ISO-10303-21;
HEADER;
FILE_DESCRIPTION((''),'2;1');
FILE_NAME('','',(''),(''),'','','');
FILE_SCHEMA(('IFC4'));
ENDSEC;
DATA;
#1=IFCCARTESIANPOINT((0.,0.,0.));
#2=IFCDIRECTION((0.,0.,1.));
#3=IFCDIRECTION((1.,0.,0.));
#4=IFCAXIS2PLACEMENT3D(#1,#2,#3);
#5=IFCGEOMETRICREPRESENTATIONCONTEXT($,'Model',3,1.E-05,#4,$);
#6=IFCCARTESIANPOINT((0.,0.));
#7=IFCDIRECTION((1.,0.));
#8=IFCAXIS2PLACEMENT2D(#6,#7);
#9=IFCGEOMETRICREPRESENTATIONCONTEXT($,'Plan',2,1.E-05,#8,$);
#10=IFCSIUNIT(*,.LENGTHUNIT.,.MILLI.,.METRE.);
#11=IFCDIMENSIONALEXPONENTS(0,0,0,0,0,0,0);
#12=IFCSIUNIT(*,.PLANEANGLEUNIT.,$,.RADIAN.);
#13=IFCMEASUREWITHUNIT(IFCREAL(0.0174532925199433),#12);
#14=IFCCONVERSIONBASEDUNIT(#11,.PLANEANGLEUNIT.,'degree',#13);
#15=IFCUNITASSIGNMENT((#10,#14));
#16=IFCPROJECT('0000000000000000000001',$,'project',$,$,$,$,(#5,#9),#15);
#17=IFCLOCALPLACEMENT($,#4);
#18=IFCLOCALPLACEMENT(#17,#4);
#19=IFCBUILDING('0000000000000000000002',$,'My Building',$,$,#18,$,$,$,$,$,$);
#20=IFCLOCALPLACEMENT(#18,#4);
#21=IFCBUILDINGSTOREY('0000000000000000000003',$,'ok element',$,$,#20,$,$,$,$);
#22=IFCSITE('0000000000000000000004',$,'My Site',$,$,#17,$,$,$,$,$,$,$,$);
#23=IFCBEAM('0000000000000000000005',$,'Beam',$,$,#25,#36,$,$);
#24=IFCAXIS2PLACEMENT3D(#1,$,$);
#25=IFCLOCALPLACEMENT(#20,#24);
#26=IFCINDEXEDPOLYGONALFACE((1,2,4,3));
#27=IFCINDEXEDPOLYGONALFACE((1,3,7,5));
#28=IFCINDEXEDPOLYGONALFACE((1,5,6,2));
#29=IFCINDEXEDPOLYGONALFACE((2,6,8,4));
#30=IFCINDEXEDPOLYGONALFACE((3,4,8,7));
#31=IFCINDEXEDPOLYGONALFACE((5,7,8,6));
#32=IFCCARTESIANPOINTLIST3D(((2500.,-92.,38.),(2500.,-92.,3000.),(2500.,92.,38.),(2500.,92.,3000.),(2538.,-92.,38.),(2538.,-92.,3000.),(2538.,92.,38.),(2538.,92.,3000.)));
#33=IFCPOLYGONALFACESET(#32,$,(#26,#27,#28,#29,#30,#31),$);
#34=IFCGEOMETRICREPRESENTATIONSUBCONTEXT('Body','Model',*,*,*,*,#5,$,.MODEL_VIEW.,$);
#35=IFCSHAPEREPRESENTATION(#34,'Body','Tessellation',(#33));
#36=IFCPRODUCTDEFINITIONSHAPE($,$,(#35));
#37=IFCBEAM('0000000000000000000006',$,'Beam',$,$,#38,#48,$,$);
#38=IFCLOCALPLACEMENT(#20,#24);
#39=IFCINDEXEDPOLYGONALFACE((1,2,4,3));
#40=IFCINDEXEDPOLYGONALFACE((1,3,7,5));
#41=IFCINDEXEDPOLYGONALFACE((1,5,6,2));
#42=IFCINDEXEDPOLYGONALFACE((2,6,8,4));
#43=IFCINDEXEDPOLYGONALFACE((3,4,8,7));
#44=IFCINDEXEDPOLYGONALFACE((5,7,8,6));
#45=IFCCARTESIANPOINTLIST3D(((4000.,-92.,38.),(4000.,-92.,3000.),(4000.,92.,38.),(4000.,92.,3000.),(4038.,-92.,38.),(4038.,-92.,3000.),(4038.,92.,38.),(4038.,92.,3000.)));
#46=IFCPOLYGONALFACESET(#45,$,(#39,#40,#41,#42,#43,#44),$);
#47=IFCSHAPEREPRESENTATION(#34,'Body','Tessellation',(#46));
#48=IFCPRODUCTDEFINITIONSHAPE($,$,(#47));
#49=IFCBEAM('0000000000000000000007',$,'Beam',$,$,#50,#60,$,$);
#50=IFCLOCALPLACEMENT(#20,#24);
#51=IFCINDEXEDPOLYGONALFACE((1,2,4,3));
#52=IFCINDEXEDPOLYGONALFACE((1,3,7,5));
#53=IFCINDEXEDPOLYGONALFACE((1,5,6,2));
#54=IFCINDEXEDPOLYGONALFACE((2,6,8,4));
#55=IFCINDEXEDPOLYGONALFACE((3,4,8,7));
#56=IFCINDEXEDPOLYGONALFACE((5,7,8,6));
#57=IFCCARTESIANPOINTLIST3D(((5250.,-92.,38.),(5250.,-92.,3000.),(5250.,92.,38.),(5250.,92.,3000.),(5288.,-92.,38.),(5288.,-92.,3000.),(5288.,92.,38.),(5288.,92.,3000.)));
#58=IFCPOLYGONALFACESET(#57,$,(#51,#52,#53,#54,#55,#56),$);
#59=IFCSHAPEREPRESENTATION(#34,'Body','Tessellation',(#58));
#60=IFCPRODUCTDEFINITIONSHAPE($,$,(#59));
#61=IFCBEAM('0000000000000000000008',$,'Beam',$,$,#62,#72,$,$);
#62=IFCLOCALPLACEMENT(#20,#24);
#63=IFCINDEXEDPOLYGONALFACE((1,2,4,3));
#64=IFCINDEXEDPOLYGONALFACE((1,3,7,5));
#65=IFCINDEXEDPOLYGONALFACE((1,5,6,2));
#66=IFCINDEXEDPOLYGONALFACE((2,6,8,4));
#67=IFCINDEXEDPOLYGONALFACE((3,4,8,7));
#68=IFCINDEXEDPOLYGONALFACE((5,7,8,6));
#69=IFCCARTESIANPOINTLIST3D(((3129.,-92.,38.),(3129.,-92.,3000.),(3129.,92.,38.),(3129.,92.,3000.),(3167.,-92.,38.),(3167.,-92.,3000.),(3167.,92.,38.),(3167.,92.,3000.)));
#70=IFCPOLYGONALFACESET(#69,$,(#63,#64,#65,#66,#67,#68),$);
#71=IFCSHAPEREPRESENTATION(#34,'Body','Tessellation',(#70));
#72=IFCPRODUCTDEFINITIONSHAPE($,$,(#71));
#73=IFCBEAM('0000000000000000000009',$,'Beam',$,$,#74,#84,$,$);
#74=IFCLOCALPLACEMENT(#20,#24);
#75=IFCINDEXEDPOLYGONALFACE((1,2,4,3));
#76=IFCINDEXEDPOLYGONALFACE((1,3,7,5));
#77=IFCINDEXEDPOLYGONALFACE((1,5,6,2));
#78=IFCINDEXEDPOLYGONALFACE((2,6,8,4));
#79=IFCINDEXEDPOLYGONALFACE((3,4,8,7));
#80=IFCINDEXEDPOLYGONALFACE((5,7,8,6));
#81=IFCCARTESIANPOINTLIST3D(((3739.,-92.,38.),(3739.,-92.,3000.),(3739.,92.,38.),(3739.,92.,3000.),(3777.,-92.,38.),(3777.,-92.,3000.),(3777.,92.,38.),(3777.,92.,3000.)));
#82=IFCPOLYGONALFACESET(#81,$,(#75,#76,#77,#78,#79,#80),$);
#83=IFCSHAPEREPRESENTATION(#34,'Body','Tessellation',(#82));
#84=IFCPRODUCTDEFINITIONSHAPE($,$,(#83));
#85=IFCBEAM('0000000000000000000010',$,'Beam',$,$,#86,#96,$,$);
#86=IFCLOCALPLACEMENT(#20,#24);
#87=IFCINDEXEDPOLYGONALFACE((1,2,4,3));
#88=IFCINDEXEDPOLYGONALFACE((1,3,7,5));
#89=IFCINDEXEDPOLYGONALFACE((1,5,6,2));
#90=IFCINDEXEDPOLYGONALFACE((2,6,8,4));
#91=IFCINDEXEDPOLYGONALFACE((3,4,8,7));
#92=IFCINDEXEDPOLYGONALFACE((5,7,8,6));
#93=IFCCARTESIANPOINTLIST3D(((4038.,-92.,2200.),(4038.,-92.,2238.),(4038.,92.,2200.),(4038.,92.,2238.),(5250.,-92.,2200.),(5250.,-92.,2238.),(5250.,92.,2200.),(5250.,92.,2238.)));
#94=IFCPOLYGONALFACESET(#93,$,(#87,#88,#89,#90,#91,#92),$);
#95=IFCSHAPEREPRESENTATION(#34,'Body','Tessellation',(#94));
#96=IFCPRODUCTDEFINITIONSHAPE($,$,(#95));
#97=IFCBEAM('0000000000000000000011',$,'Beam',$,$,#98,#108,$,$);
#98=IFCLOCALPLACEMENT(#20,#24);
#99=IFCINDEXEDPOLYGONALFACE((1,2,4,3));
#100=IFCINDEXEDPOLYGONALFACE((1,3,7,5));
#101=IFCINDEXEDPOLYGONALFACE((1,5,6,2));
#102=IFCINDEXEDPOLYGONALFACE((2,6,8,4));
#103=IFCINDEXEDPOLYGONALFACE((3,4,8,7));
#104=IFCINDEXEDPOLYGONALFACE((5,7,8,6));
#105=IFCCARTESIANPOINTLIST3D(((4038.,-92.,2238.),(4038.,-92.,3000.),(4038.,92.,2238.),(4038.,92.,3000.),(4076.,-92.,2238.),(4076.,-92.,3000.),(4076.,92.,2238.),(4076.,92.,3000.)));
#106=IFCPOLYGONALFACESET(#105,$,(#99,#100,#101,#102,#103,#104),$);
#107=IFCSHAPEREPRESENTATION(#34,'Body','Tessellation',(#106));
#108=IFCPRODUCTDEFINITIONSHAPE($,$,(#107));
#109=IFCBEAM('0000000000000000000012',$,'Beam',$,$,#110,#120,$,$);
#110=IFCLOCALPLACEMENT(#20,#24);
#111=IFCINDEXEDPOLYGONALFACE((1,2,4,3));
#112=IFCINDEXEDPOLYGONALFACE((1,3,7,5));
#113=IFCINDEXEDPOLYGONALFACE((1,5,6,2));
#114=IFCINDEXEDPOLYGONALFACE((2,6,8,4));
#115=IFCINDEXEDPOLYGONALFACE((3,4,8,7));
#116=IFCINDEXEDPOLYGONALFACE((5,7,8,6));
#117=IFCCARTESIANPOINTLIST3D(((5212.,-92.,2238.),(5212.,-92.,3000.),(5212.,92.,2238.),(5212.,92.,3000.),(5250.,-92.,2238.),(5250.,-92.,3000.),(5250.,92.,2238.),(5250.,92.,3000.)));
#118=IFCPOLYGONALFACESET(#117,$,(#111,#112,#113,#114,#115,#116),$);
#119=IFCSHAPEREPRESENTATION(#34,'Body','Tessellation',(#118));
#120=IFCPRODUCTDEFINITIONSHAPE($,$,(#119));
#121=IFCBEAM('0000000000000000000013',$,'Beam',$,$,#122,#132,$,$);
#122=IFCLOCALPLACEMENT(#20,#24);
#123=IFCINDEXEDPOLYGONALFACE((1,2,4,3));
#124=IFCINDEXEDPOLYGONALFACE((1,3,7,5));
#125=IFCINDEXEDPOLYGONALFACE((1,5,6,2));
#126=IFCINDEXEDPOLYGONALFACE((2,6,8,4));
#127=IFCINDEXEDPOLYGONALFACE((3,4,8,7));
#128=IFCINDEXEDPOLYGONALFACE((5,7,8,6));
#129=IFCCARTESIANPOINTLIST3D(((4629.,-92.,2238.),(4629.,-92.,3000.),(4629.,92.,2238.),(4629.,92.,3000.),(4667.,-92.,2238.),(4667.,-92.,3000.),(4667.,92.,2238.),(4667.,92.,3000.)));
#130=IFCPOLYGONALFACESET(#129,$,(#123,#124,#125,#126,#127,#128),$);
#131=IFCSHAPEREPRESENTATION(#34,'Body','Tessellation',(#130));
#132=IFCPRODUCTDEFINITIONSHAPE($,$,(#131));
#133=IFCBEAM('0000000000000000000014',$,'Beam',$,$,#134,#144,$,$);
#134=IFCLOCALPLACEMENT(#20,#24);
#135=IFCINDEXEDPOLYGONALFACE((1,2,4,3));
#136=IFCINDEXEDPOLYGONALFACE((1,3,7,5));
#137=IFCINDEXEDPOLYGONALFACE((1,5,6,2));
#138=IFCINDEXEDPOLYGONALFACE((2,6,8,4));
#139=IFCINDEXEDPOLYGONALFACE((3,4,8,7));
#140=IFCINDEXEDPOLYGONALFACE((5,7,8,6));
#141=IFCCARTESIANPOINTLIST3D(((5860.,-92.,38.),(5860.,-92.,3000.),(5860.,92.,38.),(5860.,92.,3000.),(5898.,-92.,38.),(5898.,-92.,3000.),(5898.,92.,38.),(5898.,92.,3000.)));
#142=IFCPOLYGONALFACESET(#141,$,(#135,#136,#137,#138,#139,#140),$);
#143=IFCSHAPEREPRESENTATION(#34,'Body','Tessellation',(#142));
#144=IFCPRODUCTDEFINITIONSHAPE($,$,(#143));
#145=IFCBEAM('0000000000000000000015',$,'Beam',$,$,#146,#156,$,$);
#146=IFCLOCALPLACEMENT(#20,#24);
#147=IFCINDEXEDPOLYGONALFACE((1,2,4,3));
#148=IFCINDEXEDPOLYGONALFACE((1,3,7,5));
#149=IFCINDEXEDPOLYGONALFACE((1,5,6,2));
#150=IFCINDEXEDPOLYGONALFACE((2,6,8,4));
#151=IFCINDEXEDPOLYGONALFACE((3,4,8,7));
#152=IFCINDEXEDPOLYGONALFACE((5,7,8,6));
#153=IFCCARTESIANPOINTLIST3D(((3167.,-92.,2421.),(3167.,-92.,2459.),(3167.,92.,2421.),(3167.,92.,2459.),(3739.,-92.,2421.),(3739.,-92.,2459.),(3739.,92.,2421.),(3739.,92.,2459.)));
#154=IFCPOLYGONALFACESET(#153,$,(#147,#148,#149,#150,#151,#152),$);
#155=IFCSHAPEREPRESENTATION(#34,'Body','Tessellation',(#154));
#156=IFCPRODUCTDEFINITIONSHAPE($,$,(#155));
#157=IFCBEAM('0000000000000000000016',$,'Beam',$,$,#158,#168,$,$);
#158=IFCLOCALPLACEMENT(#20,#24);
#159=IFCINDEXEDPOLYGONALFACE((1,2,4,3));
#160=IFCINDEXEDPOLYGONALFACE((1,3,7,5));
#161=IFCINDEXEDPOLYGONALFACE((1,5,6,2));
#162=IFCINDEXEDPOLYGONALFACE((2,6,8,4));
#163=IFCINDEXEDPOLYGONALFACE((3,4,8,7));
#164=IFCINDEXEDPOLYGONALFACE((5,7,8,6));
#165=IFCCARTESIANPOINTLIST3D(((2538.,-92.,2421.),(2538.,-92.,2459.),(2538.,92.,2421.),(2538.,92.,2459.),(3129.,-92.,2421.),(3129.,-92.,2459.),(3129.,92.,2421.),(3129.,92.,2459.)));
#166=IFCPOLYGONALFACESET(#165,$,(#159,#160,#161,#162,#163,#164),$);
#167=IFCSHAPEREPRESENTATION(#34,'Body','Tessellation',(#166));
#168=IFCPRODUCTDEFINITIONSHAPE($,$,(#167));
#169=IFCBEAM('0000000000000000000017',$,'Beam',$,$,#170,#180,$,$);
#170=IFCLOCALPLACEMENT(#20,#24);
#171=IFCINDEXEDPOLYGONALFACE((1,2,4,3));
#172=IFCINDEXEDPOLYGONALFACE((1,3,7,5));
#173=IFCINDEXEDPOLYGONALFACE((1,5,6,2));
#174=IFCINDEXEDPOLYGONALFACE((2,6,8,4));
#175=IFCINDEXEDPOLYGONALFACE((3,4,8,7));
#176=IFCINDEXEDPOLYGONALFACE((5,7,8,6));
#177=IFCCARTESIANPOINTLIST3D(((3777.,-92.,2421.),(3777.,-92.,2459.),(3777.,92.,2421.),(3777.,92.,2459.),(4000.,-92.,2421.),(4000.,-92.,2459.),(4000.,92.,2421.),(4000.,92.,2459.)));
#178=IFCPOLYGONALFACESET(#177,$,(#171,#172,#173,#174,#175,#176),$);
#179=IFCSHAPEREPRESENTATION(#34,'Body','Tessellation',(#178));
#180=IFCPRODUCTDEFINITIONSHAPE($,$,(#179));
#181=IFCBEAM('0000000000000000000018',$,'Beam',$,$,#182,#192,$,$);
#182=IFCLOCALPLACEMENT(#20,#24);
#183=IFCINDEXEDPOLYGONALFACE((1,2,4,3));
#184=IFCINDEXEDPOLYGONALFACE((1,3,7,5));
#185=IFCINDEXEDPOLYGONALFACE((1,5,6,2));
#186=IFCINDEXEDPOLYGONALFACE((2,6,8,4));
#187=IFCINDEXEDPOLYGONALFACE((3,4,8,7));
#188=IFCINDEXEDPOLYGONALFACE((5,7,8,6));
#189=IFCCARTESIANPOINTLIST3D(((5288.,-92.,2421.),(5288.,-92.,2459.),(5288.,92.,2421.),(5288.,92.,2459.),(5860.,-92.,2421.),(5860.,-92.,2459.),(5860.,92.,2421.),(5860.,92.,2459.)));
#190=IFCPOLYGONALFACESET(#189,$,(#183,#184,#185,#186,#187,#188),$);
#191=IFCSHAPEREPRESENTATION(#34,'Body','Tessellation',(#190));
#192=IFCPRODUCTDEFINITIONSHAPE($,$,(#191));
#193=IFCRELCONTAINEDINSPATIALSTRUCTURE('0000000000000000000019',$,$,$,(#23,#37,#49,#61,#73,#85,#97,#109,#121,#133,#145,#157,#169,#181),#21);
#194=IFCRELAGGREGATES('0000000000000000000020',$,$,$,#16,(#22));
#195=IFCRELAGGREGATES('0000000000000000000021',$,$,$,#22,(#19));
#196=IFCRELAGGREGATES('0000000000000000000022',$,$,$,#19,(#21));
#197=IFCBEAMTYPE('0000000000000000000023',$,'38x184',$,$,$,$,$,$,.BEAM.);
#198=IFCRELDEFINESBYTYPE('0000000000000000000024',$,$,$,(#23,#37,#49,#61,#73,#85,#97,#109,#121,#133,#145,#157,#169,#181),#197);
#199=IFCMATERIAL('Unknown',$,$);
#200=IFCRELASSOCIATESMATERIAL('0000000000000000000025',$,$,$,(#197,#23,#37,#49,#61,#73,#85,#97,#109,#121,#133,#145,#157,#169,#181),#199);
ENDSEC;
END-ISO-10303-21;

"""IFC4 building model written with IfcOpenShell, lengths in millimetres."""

from ifc_helpers import new_model, entity, si_unit, converted_unit, frame, origin_with_axes, origin_2d_with_axis, place, context, subcontext, project, spatial, rectangle, extrude, material, material_profile, profile_set, profile_usage, type_object, element, save


model = new_model("IFC4")

# Units and contexts
model_context = context("Model", 3, precision=1e-05, world=origin_with_axes())
plan_context = context("Plan", 2, precision=1e-05, world=origin_2d_with_axis())
body_context = subcontext(model_context, "Body", "Model", "MODEL_VIEW")
ifc_project = project(units=[si_unit("LENGTHUNIT", "METRE", prefix="MILLI"), converted_unit("PLANEANGLEUNIT", "degree", entity("IfcReal", 0.0174532925199433), si_unit("PLANEANGLEUNIT", "RADIAN"), dimensions=[0, 0, 0, 0, 0, 0, 0])], contexts=[model_context, plan_context])

# Site, building, storey
site_placement = place(None, origin_with_axes())
site = spatial("IfcSite", under=ifc_project, at=site_placement, Name="My Site")
building_placement = place(site_placement, origin_with_axes())
building = spatial("IfcBuilding", under=site, at=building_placement, Name="My Building")
storey_placement = place(building_placement, origin_with_axes())
storey = spatial("IfcBuildingStorey", under=building, at=storey_placement, Name="ok element")

# Beams
ifc_material = material(Name="Unknown")
ifc_material_profile = material_profile(ifc_material, rectangle(XDim=184.0, YDim=38.0))
ifc_profile_set = profile_set([ifc_material_profile], Name="vurenhout")
beam_type = type_object("IfcBeamType", Name="38x184", PredefinedType="BEAM", material=ifc_profile_set)
ifc_profile_usage_1 = profile_usage(ifc_profile_set, cardinal=2)
beam_1_placement = place(storey_placement, frame((2538.0, 0.0, 38.0), z_axis=(0.0, 0.0, 1.0), x_axis=(0.0, 1.0, 0.0)))
element("IfcBeam", 1, at=beam_1_placement, inside=storey, type_object=beam_type, material=ifc_profile_usage_1, Name="Beam", context=body_context, shape_type="SweptSolid", body=[
    extrude(rectangle(XDim=184.0, YDim=38.0), frame((0.0, 19.0, 0.0), z_axis=(0.0, 0.0, 1.0), x_axis=(1.0, 0.0, 0.0)), (0.0, 0.0, 1.0), 2962.0),
])
ifc_profile_usage_2 = profile_usage(ifc_profile_set, cardinal=2)
beam_2_placement = place(storey_placement, frame((4038.0, 0.0, 38.0), z_axis=(0.0, 0.0, 1.0), x_axis=(0.0, 1.0, 0.0)))
element("IfcBeam", 2, at=beam_2_placement, inside=storey, type_object=beam_type, material=ifc_profile_usage_2, Name="Beam", context=body_context, shape_type="SweptSolid", body=[
    extrude(rectangle(XDim=184.0, YDim=38.0), frame((0.0, 19.0, 0.0), z_axis=(0.0, 0.0, 1.0), x_axis=(1.0, 0.0, 0.0)), (0.0, 0.0, 1.0), 2962.0),
])
ifc_profile_usage_3 = profile_usage(ifc_profile_set, cardinal=2)
beam_3_placement = place(storey_placement, frame((5288.0, 0.0, 38.0), z_axis=(0.0, 0.0, 1.0), x_axis=(0.0, 1.0, 0.0)))
element("IfcBeam", 3, at=beam_3_placement, inside=storey, type_object=beam_type, material=ifc_profile_usage_3, Name="Beam", context=body_context, shape_type="SweptSolid", body=[
    extrude(rectangle(XDim=184.0, YDim=38.0), frame((0.0, 19.0, 0.0), z_axis=(0.0, 0.0, 1.0), x_axis=(1.0, 0.0, 0.0)), (0.0, 0.0, 1.0), 2962.0),
])
ifc_profile_usage_4 = profile_usage(ifc_profile_set, cardinal=5)
beam_4_placement = place(storey_placement, frame((3148.0, 0.0, 38.0), z_axis=(0.0, 0.0, 1.0), x_axis=(0.0, 1.0, 0.0)))
element("IfcBeam", 4, at=beam_4_placement, inside=storey, type_object=beam_type, material=ifc_profile_usage_4, Name="Beam", context=body_context, shape_type="SweptSolid", body=[
    extrude(rectangle(XDim=184.0, YDim=38.0), origin_with_axes(), (0.0, 0.0, 1.0), 2962.0),
])
ifc_profile_usage_5 = profile_usage(ifc_profile_set, cardinal=5)
beam_5_placement = place(storey_placement, frame((3758.0, 0.0, 38.0), z_axis=(0.0, 0.0, 1.0), x_axis=(0.0, 1.0, 0.0)))
element("IfcBeam", 5, at=beam_5_placement, inside=storey, type_object=beam_type, material=ifc_profile_usage_5, Name="Beam", context=body_context, shape_type="SweptSolid", body=[
    extrude(rectangle(XDim=184.0, YDim=38.0), origin_with_axes(), (0.0, 0.0, 1.0), 2962.0),
])
ifc_profile_usage_6 = profile_usage(ifc_profile_set, cardinal=2)
beam_6_placement = place(storey_placement, frame((4038.0, 0.0, 2200.0), z_axis=(1.0, 0.0, 0.0), x_axis=(0.0, 1.0, 0.0)))
element("IfcBeam", 6, at=beam_6_placement, inside=storey, type_object=beam_type, material=ifc_profile_usage_6, Name="Beam", context=body_context, shape_type="SweptSolid", body=[
    extrude(rectangle(XDim=184.0, YDim=38.0), frame((0.0, 19.0, 0.0), z_axis=(0.0, 0.0, 1.0), x_axis=(1.0, 0.0, 0.0)), (0.0, 0.0, 1.0), 1212.0),
])
ifc_profile_usage_7 = profile_usage(ifc_profile_set, cardinal=2)
beam_7_placement = place(storey_placement, frame((4076.0, 0.0, 2238.0), z_axis=(0.0, 0.0, 1.0), x_axis=(0.0, 1.0, 0.0)))
element("IfcBeam", 7, at=beam_7_placement, inside=storey, type_object=beam_type, material=ifc_profile_usage_7, Name="Beam", context=body_context, shape_type="SweptSolid", body=[
    extrude(rectangle(XDim=184.0, YDim=38.0), frame((0.0, 19.0, 0.0), z_axis=(0.0, 0.0, 1.0), x_axis=(1.0, 0.0, 0.0)), (0.0, 0.0, 1.0), 762.0),
])
ifc_profile_usage_8 = profile_usage(ifc_profile_set, cardinal=2)
beam_8_placement = place(storey_placement, frame((5250.0, 0.0, 2238.0), z_axis=(0.0, 0.0, 1.0), x_axis=(0.0, 1.0, 0.0)))
element("IfcBeam", 8, at=beam_8_placement, inside=storey, type_object=beam_type, material=ifc_profile_usage_8, Name="Beam", context=body_context, shape_type="SweptSolid", body=[
    extrude(rectangle(XDim=184.0, YDim=38.0), frame((0.0, 19.0, 0.0), z_axis=(0.0, 0.0, 1.0), x_axis=(1.0, 0.0, 0.0)), (0.0, 0.0, 1.0), 762.0),
])
ifc_profile_usage_9 = profile_usage(ifc_profile_set, cardinal=2)
beam_9_placement = place(storey_placement, frame((4667.0, 0.0, 2238.0), z_axis=(0.0, 0.0, 1.0), x_axis=(0.0, 1.0, 0.0)))
element("IfcBeam", 9, at=beam_9_placement, inside=storey, type_object=beam_type, material=ifc_profile_usage_9, Name="Beam", context=body_context, shape_type="SweptSolid", body=[
    extrude(rectangle(XDim=184.0, YDim=38.0), frame((0.0, 19.0, 0.0), z_axis=(0.0, 0.0, 1.0), x_axis=(1.0, 0.0, 0.0)), (0.0, 0.0, 1.0), 762.0),
])
ifc_profile_usage_10 = profile_usage(ifc_profile_set, cardinal=2)
beam_10_placement = place(storey_placement, frame((5898.0, 0.0, 38.0), z_axis=(0.0, 0.0, 1.0), x_axis=(0.0, 1.0, 0.0)))
element("IfcBeam", 10, at=beam_10_placement, inside=storey, type_object=beam_type, material=ifc_profile_usage_10, Name="Beam", context=body_context, shape_type="SweptSolid", body=[
    extrude(rectangle(XDim=184.0, YDim=38.0), frame((0.0, 19.0, 0.0), z_axis=(0.0, 0.0, 1.0), x_axis=(1.0, 0.0, 0.0)), (0.0, 0.0, 1.0), 2962.0),
])
ifc_profile_usage_11 = profile_usage(ifc_profile_set, cardinal=2)
beam_11_placement = place(storey_placement, frame((3167.0, 0.0, 2421.0), z_axis=(1.0, 0.0, 0.0), x_axis=(0.0, 1.0, 0.0)))
element("IfcBeam", 11, at=beam_11_placement, inside=storey, type_object=beam_type, material=ifc_profile_usage_11, Name="Beam", context=body_context, shape_type="SweptSolid", body=[
    extrude(rectangle(XDim=184.0, YDim=38.0), frame((0.0, 19.0, 0.0), z_axis=(0.0, 0.0, 1.0), x_axis=(1.0, 0.0, 0.0)), (0.0, 0.0, 1.0), 572.0),
])
ifc_profile_usage_12 = profile_usage(ifc_profile_set, cardinal=2)
beam_12_placement = place(storey_placement, frame((2538.0, 0.0, 2421.0), z_axis=(1.0, 0.0, 0.0), x_axis=(0.0, 1.0, 0.0)))
element("IfcBeam", 12, at=beam_12_placement, inside=storey, type_object=beam_type, material=ifc_profile_usage_12, Name="Beam", context=body_context, shape_type="SweptSolid", body=[
    extrude(rectangle(XDim=184.0, YDim=38.0), frame((0.0, 19.0, 0.0), z_axis=(0.0, 0.0, 1.0), x_axis=(1.0, 0.0, 0.0)), (0.0, 0.0, 1.0), 591.0),
])
ifc_profile_usage_13 = profile_usage(ifc_profile_set, cardinal=2)
beam_13_placement = place(storey_placement, frame((3777.0, 0.0, 2421.0), z_axis=(1.0, 0.0, 0.0), x_axis=(0.0, 1.0, 0.0)))
element("IfcBeam", 13, at=beam_13_placement, inside=storey, type_object=beam_type, material=ifc_profile_usage_13, Name="Beam", context=body_context, shape_type="SweptSolid", body=[
    extrude(rectangle(XDim=184.0, YDim=38.0), frame((0.0, 19.0, 0.0), z_axis=(0.0, 0.0, 1.0), x_axis=(1.0, 0.0, 0.0)), (0.0, 0.0, 1.0), 223.0),
])
ifc_profile_usage_14 = profile_usage(ifc_profile_set, cardinal=2)
beam_14_placement = place(storey_placement, frame((5288.0, 0.0, 2421.0), z_axis=(1.0, 0.0, 0.0), x_axis=(0.0, 1.0, 0.0)))
element("IfcBeam", 14, at=beam_14_placement, inside=storey, type_object=beam_type, material=ifc_profile_usage_14, Name="Beam", context=body_context, shape_type="SweptSolid", body=[
    extrude(rectangle(XDim=184.0, YDim=38.0), frame((0.0, 19.0, 0.0), z_axis=(0.0, 0.0, 1.0), x_axis=(1.0, 0.0, 0.0)), (0.0, 0.0, 1.0), 572.0),
])

save(model, "model.ifc")
